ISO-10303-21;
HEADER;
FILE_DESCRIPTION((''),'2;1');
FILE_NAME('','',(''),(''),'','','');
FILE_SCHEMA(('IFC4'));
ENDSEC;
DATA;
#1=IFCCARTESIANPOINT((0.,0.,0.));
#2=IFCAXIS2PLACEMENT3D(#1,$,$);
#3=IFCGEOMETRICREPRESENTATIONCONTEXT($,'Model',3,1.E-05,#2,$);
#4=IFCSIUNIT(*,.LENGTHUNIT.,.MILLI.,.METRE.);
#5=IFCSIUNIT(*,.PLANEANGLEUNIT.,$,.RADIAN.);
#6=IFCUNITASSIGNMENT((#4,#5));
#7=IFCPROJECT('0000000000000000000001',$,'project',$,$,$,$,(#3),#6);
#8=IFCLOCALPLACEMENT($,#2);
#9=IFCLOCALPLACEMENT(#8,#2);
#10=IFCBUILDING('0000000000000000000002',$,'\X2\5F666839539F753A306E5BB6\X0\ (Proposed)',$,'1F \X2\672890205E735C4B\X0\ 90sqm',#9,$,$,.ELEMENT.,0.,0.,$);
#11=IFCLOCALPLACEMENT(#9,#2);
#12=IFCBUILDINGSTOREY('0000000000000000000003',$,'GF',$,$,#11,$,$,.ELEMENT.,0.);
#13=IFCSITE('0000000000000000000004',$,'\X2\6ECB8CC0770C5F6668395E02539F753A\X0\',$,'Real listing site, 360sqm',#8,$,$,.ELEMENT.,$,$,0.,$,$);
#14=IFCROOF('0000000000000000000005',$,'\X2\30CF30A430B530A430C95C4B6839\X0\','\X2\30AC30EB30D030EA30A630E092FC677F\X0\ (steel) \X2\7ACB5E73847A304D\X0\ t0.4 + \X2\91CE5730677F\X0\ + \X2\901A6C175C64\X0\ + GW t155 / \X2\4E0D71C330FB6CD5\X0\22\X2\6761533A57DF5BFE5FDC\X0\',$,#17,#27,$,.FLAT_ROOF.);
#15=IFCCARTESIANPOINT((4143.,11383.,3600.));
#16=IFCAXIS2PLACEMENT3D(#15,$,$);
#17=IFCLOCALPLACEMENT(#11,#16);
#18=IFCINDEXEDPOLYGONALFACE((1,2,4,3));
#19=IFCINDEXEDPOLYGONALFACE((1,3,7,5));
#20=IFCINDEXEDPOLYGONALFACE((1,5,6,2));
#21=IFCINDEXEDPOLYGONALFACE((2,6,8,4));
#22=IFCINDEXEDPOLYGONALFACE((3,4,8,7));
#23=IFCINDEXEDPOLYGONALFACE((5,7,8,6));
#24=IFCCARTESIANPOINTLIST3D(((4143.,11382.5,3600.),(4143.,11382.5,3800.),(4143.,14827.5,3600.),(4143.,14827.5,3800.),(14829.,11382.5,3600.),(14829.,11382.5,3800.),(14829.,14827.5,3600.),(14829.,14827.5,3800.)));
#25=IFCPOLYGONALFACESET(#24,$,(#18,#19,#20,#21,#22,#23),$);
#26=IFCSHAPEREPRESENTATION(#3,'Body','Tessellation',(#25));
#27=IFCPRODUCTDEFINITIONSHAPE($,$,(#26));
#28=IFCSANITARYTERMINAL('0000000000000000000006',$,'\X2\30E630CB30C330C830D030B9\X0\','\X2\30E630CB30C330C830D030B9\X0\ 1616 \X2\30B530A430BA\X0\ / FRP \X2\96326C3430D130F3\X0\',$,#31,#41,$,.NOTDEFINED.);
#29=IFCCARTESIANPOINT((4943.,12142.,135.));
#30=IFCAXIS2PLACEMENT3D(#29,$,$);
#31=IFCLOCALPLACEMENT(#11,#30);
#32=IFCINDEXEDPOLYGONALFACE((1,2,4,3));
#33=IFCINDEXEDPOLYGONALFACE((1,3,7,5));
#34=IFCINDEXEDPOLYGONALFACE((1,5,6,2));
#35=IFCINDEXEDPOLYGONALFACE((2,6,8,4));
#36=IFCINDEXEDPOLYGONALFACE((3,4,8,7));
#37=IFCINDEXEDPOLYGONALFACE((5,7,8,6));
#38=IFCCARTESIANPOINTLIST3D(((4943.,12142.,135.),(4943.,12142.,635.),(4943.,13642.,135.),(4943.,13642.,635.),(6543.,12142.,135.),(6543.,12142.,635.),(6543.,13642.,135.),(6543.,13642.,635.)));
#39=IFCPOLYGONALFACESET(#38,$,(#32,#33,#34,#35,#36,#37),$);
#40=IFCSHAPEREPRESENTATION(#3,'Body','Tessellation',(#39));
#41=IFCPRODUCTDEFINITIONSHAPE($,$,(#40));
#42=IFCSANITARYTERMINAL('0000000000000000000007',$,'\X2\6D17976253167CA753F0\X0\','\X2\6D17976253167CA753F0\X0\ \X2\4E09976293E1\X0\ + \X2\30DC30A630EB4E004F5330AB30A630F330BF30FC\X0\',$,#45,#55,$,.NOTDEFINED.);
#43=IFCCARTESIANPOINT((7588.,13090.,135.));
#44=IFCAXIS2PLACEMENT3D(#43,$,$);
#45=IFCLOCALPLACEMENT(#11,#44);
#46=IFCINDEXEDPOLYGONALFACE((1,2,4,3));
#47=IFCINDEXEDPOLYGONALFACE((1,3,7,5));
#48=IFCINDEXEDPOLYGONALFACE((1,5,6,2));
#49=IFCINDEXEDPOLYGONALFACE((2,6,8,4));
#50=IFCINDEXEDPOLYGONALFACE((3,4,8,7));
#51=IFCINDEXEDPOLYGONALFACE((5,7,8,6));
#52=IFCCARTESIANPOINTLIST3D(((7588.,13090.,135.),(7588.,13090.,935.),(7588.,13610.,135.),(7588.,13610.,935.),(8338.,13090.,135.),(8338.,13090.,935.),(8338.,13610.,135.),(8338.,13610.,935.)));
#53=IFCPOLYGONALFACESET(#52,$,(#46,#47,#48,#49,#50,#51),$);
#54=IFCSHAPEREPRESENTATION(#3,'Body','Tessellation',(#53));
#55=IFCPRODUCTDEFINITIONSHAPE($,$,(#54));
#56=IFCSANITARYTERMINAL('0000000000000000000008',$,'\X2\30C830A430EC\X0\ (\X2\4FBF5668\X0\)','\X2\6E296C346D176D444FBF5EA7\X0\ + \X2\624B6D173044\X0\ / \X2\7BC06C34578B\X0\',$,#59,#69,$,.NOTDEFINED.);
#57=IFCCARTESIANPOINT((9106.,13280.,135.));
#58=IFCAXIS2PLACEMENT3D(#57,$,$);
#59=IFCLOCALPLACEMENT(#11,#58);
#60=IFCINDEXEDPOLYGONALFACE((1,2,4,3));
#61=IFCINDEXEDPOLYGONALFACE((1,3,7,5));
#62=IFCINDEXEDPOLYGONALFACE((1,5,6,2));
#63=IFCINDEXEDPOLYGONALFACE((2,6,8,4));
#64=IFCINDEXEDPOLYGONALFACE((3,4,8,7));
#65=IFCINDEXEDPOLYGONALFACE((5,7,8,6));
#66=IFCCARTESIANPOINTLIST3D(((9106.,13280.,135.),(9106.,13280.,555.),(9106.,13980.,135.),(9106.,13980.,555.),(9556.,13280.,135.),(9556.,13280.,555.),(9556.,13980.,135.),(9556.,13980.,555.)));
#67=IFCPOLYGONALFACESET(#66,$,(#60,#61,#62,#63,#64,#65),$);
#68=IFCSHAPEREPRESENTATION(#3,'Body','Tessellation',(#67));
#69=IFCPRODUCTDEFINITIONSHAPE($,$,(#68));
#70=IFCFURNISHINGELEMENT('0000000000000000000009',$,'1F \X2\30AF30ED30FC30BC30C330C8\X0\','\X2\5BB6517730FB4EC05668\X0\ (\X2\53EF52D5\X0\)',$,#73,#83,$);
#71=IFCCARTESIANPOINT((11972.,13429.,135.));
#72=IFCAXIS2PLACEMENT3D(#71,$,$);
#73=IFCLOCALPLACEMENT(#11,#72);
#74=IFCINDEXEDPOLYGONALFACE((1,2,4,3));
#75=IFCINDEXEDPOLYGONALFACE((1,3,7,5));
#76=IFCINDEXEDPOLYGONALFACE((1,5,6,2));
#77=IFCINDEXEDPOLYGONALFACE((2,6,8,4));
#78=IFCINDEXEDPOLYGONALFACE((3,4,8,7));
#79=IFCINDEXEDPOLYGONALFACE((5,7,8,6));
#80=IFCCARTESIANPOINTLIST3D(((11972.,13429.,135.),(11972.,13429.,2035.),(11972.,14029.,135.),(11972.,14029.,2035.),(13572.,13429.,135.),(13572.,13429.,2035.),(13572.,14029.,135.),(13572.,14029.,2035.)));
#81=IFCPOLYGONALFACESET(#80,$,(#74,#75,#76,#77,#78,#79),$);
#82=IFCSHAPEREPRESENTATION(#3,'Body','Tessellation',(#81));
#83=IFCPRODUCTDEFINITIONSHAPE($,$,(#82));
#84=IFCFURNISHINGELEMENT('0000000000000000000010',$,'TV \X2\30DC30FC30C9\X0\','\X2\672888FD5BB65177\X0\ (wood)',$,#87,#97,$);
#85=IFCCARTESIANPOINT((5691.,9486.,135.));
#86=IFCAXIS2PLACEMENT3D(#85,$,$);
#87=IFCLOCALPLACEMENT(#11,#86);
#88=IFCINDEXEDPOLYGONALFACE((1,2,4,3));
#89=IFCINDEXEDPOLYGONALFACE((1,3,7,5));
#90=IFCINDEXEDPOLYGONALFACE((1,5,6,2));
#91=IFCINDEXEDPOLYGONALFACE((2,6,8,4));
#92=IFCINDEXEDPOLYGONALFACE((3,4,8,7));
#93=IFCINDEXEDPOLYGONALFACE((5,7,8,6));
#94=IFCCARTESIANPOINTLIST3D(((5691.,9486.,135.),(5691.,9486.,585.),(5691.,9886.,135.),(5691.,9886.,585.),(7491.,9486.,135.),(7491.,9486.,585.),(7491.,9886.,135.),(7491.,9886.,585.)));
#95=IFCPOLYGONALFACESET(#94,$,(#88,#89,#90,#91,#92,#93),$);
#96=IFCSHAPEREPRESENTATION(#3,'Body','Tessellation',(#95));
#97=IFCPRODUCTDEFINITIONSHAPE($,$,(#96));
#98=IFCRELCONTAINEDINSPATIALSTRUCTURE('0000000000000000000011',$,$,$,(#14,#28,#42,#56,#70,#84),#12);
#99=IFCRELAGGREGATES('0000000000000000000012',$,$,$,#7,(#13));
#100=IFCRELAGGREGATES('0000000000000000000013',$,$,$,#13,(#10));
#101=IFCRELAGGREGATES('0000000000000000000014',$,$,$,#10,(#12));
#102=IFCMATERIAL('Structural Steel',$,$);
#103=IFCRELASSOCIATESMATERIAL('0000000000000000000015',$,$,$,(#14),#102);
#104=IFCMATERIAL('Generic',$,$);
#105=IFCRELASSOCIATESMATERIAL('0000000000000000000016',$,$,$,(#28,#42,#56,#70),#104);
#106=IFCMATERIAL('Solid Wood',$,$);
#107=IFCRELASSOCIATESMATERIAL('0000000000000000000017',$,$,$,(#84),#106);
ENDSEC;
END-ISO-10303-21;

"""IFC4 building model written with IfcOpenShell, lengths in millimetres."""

from ifc_helpers import new_model, si_unit, frame, frame_2d, origin, place, context, project, spatial, rectangle, extrude, material, element, save


model = new_model("IFC4")

# Units and contexts
model_context = context("Model", 3, precision=1e-05, world=origin())
ifc_project = project(units=[si_unit("LENGTHUNIT", "METRE", prefix="MILLI"), si_unit("PLANEANGLEUNIT", "RADIAN")], contexts=[model_context])

# Site, building, storey
site_placement = place(None, origin())
site = spatial("IfcSite", under=ifc_project, at=site_placement, Name="滋賀県彦根市原町", ObjectType="Real listing site, 360sqm", CompositionType="ELEMENT", RefElevation=0.0)
building_placement = place(site_placement, origin())
building = spatial("IfcBuilding", under=site, at=building_placement, Name="彦根原町の家 (Proposed)", ObjectType="1F 木造平屋 90sqm", CompositionType="ELEMENT", ElevationOfRefHeight=0.0, ElevationOfTerrain=0.0)
storey_placement = place(building_placement, origin())
storey = spatial("IfcBuildingStorey", under=building, at=storey_placement, Name="GF", CompositionType="ELEMENT", Elevation=0.0)

# Shared definitions
ifc_material_1 = material(Name="Solid Wood")

# Roof
ifc_material_2 = material(Name="Structural Steel")
roof_placement = place(storey_placement, frame((4143.0, 11383.0, 3600.0)))
element("IfcRoof", 1, at=roof_placement, inside=storey, material=ifc_material_2, Name="ハイサイド屋根", Description="ガルバリウム鋼板 (steel) 立平葺き t0.4 + 野地板 + 通気層 + GW t155 / 不燃・法22条区域対応", PredefinedType="FLAT_ROOF", context=model_context, shape_type="SweptSolid", body=[
    extrude(rectangle(XDim=10686.0, YDim=3445.0, at=frame_2d((5343.0, 1722.0))), frame((4143.0, 11383.0, 3600.0)), (0.0, 0.0, 1.0), 200.0),
])

# Sanitary terminals
ifc_material_3 = material(Name="Generic")
sanitary_terminal_1_placement = place(storey_placement, frame((4943.0, 12142.0, 135.0)))
element("IfcSanitaryTerminal", 2, at=sanitary_terminal_1_placement, inside=storey, material=ifc_material_3, Name="ユニットバス", Description="ユニットバス 1616 サイズ / FRP 防水パン", PredefinedType="NOTDEFINED", context=model_context, shape_type="SweptSolid", body=[
    extrude(rectangle(XDim=1600.0, YDim=1500.0, at=frame_2d((800.0, 750.0))), frame((4943.0, 12142.0, 135.0)), (0.0, 0.0, 1.0), 500.0),
])
sanitary_terminal_2_placement = place(storey_placement, frame((7588.0, 13090.0, 135.0)))
element("IfcSanitaryTerminal", 3, at=sanitary_terminal_2_placement, inside=storey, material=ifc_material_3, Name="洗面化粧台", Description="洗面化粧台 三面鏡 + ボウル一体カウンター", PredefinedType="NOTDEFINED", context=model_context, shape_type="SweptSolid", body=[
    extrude(rectangle(XDim=750.0, YDim=520.0, at=frame_2d((375.0, 260.0))), frame((7588.0, 13090.0, 135.0)), (0.0, 0.0, 1.0), 800.0),
])
sanitary_terminal_3_placement = place(storey_placement, frame((9106.0, 13280.0, 135.0)))
element("IfcSanitaryTerminal", 4, at=sanitary_terminal_3_placement, inside=storey, material=ifc_material_3, Name="トイレ (便器)", Description="温水洗浄便座 + 手洗い / 節水型", PredefinedType="NOTDEFINED", context=model_context, shape_type="SweptSolid", body=[
    extrude(rectangle(XDim=450.0, YDim=700.0, at=frame_2d((225.0, 350.0))), frame((9106.0, 13280.0, 135.0)), (0.0, 0.0, 1.0), 420.0),
])

# Furnishing elements
furnishing_1_placement = place(storey_placement, frame((11972.0, 13429.0, 135.0)))
element("IfcFurnishingElement", 5, at=furnishing_1_placement, inside=storey, material=ifc_material_3, Name="1F クローゼット", Description="家具・什器 (可動)", context=model_context, shape_type="SweptSolid", body=[
    extrude(rectangle(XDim=1600.0, YDim=600.0, at=frame_2d((800.0, 300.0))), frame((11972.0, 13429.0, 135.0)), (0.0, 0.0, 1.0), 1900.0),
])
furnishing_2_placement = place(storey_placement, frame((5691.0, 9486.0, 135.0)))
element("IfcFurnishingElement", 6, at=furnishing_2_placement, inside=storey, material=ifc_material_1, Name="TV ボード", Description="木製家具 (wood)", context=model_context, shape_type="SweptSolid", body=[
    extrude(rectangle(XDim=1800.0, YDim=400.0, at=frame_2d((900.0, 200.0))), frame((5691.0, 9486.0, 135.0)), (0.0, 0.0, 1.0), 450.0),
])

save(model, "model.ifc")
